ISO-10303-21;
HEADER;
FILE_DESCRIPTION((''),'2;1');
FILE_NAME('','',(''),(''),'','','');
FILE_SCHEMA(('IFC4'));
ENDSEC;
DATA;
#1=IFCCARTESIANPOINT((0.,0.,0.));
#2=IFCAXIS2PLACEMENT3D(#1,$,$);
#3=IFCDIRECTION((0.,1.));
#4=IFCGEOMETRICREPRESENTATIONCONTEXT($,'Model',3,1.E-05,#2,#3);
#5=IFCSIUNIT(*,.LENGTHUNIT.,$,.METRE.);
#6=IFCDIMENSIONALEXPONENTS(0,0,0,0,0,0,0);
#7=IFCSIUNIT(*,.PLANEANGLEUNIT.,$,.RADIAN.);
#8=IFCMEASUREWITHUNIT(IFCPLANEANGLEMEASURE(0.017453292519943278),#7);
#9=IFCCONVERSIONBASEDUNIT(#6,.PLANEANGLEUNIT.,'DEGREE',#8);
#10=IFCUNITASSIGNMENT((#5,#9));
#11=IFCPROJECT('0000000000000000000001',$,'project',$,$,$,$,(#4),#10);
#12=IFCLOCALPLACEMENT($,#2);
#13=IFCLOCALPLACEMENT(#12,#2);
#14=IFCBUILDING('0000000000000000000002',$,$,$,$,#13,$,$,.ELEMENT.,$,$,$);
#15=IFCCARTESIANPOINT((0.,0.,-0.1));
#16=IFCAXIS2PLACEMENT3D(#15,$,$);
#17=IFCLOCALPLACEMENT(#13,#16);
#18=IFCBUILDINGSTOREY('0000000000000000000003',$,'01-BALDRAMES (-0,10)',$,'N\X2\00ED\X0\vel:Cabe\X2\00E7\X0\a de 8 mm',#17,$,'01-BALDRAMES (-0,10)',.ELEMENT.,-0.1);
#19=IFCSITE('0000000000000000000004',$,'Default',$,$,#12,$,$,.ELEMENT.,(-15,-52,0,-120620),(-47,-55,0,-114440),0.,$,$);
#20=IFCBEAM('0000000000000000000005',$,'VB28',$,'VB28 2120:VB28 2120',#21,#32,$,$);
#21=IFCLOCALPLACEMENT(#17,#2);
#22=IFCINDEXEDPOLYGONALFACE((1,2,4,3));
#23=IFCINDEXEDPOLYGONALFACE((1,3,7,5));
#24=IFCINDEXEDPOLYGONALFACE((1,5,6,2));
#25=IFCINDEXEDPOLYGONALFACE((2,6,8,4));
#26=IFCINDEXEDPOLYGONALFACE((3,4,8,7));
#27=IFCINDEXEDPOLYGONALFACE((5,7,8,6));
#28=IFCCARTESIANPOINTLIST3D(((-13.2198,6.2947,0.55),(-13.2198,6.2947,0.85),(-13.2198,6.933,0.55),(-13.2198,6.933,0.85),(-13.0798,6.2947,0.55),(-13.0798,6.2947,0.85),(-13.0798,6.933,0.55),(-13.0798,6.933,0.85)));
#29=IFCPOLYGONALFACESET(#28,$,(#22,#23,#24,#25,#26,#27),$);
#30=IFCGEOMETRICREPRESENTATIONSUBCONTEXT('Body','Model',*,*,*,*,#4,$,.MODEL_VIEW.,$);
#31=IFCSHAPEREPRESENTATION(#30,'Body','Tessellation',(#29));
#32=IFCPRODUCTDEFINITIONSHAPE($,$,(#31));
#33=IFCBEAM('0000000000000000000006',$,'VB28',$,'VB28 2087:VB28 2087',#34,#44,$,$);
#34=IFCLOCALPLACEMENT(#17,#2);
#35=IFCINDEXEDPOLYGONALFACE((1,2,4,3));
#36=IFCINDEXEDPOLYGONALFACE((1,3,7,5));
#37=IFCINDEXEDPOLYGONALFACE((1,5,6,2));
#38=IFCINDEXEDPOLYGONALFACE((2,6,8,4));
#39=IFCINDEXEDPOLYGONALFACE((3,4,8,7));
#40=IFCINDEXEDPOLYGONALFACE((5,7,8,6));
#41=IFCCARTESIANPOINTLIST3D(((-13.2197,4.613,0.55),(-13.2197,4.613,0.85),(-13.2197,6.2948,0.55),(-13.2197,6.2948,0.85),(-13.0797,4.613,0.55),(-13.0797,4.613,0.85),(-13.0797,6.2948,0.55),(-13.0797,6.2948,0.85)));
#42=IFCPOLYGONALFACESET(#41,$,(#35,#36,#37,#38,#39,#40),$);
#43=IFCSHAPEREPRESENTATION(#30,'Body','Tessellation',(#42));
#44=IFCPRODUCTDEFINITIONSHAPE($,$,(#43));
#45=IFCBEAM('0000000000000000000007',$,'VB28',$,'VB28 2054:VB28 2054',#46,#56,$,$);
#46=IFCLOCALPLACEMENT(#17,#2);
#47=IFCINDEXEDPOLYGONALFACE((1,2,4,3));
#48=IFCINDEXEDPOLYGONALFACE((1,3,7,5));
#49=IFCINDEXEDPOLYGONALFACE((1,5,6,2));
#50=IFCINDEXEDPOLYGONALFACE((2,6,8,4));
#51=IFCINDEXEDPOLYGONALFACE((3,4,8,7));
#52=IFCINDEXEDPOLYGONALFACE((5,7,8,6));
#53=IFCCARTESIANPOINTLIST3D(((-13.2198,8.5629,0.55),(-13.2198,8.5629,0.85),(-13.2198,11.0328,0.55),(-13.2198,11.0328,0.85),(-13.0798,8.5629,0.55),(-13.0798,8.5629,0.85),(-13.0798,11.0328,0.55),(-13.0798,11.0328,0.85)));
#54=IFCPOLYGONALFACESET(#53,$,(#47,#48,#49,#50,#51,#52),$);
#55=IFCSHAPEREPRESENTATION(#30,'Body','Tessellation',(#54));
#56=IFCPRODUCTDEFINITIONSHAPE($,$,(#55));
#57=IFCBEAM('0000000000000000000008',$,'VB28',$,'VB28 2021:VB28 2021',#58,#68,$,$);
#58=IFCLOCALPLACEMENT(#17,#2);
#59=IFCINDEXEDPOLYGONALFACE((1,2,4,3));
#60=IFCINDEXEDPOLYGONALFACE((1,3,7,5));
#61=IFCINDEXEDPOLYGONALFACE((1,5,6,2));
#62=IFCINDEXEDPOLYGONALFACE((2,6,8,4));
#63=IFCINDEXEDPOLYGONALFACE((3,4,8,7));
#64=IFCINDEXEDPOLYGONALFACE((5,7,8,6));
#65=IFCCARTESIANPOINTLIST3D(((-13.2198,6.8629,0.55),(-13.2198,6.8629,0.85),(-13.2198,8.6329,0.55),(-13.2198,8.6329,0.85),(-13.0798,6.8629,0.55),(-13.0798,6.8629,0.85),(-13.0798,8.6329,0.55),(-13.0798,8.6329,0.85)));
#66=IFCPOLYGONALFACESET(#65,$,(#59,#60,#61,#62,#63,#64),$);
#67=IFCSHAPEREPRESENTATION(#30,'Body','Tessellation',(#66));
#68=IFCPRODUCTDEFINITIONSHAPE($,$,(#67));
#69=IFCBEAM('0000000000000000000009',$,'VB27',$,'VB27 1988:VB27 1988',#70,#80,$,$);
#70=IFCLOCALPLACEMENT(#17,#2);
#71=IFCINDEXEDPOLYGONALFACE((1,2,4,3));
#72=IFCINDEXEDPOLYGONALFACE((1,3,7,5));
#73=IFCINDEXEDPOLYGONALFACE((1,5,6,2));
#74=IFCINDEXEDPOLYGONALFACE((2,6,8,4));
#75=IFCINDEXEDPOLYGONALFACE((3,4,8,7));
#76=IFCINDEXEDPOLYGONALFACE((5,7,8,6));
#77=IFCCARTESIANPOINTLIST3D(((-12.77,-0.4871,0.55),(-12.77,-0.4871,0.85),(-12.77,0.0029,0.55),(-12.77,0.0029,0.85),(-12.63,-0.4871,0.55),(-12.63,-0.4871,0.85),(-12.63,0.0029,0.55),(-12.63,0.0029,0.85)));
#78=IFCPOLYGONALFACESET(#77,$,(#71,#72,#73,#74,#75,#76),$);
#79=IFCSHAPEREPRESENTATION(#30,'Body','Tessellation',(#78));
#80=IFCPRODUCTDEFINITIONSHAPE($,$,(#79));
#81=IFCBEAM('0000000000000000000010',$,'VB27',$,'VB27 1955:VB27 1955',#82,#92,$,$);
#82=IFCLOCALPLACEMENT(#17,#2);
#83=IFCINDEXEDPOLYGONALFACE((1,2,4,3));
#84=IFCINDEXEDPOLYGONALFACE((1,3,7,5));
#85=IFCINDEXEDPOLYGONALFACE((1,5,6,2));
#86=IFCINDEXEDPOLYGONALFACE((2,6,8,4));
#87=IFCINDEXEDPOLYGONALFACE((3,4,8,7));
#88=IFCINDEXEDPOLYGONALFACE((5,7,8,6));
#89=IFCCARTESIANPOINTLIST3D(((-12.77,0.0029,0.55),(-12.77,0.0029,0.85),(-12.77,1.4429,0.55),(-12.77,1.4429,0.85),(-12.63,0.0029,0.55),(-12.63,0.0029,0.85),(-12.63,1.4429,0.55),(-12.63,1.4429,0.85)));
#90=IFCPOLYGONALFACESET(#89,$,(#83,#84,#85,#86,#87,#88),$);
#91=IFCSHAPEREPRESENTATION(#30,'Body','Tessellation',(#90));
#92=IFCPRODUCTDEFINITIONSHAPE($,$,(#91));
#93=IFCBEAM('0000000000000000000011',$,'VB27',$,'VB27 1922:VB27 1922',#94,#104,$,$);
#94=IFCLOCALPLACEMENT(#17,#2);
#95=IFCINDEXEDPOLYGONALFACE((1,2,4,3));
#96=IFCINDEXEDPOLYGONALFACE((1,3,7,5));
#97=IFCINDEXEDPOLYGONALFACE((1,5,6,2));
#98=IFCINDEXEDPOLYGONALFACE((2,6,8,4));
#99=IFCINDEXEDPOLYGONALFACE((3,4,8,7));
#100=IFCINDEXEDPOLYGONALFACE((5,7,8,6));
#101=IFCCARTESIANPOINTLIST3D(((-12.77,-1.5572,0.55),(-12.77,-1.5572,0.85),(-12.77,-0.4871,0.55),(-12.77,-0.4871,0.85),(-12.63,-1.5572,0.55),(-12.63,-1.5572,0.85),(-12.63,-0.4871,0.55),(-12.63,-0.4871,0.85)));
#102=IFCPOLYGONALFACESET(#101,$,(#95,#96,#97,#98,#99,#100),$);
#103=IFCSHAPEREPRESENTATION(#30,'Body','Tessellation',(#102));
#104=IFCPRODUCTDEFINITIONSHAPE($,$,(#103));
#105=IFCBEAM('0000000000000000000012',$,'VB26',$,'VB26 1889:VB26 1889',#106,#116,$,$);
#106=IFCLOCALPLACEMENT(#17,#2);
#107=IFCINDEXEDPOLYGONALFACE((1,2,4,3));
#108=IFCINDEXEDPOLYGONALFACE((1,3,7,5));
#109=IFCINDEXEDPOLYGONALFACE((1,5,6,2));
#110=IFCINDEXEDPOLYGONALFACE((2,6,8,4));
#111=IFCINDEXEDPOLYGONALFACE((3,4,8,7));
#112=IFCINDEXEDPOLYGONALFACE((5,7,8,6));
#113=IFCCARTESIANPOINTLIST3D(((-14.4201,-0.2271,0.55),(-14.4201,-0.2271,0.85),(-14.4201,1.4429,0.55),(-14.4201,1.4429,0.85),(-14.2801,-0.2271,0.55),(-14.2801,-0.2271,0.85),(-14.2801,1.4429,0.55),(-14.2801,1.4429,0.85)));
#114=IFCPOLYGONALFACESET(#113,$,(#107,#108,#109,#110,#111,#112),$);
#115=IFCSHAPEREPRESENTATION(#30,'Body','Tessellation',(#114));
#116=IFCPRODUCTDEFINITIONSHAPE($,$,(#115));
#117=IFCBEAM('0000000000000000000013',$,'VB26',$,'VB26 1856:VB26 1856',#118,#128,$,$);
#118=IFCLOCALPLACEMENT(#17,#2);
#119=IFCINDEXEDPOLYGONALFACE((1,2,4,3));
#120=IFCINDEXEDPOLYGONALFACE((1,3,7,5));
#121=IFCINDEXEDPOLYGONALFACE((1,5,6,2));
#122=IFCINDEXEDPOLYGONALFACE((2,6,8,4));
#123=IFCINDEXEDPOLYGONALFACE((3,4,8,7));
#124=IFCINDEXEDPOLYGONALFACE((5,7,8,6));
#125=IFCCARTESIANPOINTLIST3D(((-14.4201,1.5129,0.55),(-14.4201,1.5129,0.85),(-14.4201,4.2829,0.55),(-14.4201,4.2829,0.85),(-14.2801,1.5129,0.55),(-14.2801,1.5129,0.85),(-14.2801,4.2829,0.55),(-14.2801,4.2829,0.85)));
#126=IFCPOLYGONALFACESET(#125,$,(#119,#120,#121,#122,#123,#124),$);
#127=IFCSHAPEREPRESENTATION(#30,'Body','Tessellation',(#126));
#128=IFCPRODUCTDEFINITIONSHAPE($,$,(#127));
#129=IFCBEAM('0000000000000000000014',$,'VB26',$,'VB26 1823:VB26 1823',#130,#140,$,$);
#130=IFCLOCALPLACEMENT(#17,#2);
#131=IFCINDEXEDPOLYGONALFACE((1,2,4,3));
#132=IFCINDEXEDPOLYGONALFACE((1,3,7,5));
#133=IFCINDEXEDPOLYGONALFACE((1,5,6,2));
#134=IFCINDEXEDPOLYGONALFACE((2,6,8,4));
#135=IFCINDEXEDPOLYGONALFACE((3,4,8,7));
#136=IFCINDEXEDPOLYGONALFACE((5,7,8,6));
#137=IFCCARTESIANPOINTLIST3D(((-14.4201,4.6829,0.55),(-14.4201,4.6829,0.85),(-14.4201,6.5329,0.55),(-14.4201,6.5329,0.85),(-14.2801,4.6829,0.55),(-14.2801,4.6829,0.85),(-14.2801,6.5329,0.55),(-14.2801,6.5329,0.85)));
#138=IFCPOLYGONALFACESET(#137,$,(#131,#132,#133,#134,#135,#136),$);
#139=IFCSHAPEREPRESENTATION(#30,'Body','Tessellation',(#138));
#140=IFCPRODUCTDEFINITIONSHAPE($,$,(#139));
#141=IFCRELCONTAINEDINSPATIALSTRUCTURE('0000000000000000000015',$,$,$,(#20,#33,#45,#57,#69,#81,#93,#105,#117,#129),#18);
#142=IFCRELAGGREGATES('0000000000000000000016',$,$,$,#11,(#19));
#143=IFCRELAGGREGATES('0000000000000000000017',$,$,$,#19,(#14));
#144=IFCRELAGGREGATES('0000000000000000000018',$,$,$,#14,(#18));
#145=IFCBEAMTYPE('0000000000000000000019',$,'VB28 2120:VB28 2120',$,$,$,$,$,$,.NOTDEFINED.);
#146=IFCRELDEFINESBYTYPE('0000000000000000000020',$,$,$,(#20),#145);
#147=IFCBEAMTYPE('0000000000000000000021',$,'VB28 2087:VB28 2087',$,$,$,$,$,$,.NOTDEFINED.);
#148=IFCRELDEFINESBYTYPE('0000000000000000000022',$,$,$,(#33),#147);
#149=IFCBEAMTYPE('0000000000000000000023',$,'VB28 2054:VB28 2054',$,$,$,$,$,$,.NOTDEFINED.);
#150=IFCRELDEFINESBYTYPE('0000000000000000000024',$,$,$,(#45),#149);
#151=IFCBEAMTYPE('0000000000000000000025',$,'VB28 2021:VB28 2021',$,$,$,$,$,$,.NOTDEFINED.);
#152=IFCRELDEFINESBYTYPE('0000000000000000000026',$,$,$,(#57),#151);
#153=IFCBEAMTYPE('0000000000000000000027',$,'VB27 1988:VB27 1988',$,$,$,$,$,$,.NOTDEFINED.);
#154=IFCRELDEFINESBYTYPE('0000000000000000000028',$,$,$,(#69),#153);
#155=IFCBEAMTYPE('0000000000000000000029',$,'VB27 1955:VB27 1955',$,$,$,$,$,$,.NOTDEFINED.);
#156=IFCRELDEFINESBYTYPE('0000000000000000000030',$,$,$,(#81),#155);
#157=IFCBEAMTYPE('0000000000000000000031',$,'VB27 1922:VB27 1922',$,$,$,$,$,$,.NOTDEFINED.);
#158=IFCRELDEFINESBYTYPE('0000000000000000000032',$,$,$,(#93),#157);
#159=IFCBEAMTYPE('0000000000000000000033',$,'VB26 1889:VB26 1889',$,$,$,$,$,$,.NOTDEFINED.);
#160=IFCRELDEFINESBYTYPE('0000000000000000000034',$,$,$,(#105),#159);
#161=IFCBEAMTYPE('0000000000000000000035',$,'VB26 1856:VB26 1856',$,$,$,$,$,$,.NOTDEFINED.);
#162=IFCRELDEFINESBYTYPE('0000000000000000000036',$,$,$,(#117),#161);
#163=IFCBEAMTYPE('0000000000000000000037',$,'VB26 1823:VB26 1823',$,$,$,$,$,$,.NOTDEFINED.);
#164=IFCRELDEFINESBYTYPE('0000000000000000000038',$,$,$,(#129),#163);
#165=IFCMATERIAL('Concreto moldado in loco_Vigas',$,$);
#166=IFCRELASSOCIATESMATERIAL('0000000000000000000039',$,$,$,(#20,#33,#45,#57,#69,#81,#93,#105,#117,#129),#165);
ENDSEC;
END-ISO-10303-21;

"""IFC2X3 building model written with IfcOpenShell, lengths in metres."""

from ifc_helpers import new_model, entity, si_unit, converted_unit, direction, frame, frame_2d, origin, place, context, subcontext, project, spatial, rectangle, extrude, material, type_object, element, save


model = new_model("IFC2X3")

# Units and contexts
model_context = context("Model", 3, precision=1e-05, world=origin(), true_north=direction((0.0, 1.0)))
body_context = subcontext(model_context, "Body", "Model", "MODEL_VIEW")
ifc_project = project(units=[si_unit("LENGTHUNIT", "METRE"), converted_unit("PLANEANGLEUNIT", "DEGREE", entity("IfcPlaneAngleMeasure", 0.017453292519943278), si_unit("PLANEANGLEUNIT", "RADIAN"), dimensions=[0, 0, 0, 0, 0, 0, 0])], contexts=[model_context])

# Site, building, storey
site_placement = place(None, origin())
site = spatial("IfcSite", under=ifc_project, at=site_placement, Name="Default", CompositionType="ELEMENT", RefLatitude=(-15, -52, 0, -120620), RefLongitude=(-47, -55, 0, -114440), RefElevation=0.0)
building_placement = place(site_placement, origin())
building = spatial("IfcBuilding", under=site, at=building_placement, CompositionType="ELEMENT")
storey_placement = place(building_placement, frame((0.0, 0.0, -0.1)))
storey = spatial("IfcBuildingStorey", under=building, at=storey_placement, Name="01-BALDRAMES (-0,10)", ObjectType="Nível:Cabeça de 8 mm", LongName="01-BALDRAMES (-0,10)", CompositionType="ELEMENT", Elevation=-0.1)

# Beams
ifc_material = material(Name="Concreto moldado in loco_Vigas")
beam_type_1 = type_object("IfcBeamType", Name="VB28 2120:VB28 2120", PredefinedType="NOTDEFINED")
beam_1_placement = place(storey_placement, origin())
element("IfcBeam", 1, at=beam_1_placement, inside=storey, type_object=beam_type_1, material=ifc_material, Name="VB28", ObjectType="VB28 2120:VB28 2120", context=body_context, shape_type="SweptSolid", body=[
    extrude(rectangle(XDim=0.3, YDim=0.6382, at=frame_2d((0.0, 0.0), x_axis=(0.0, 1.0))), frame((-13.2198, 6.6139, 0.7), z_axis=(1.0, 0.0, 0.0), x_axis=(0.0, -1.0, 0.0)), (0.0, 0.0, 1.0), 0.14),
])
beam_type_2 = type_object("IfcBeamType", Name="VB28 2087:VB28 2087", PredefinedType="NOTDEFINED")
beam_2_placement = place(storey_placement, origin())
element("IfcBeam", 2, at=beam_2_placement, inside=storey, type_object=beam_type_2, material=ifc_material, Name="VB28", ObjectType="VB28 2087:VB28 2087", context=body_context, shape_type="SweptSolid", body=[
    extrude(rectangle(XDim=0.3, YDim=1.6817, at=frame_2d((0.0, 0.0), x_axis=(0.0, 1.0))), frame((-13.2197, 5.4539, 0.7), z_axis=(1.0, 0.0, 0.0), x_axis=(0.0, -1.0, 0.0)), (0.0, 0.0, 1.0), 0.14),
])
beam_type_3 = type_object("IfcBeamType", Name="VB28 2054:VB28 2054", PredefinedType="NOTDEFINED")
beam_3_placement = place(storey_placement, origin())
element("IfcBeam", 3, at=beam_3_placement, inside=storey, type_object=beam_type_3, material=ifc_material, Name="VB28", ObjectType="VB28 2054:VB28 2054", context=body_context, shape_type="SweptSolid", body=[
    extrude(rectangle(XDim=0.3, YDim=2.4699, at=frame_2d((0.0, 0.0), x_axis=(0.0, 1.0))), frame((-13.2198, 9.7979, 0.7), z_axis=(1.0, 0.0, 0.0), x_axis=(0.0, -1.0, 0.0)), (0.0, 0.0, 1.0), 0.14),
])
beam_type_4 = type_object("IfcBeamType", Name="VB28 2021:VB28 2021", PredefinedType="NOTDEFINED")
beam_4_placement = place(storey_placement, origin())
element("IfcBeam", 4, at=beam_4_placement, inside=storey, type_object=beam_type_4, material=ifc_material, Name="VB28", ObjectType="VB28 2021:VB28 2021", context=body_context, shape_type="SweptSolid", body=[
    extrude(rectangle(XDim=0.3, YDim=1.77, at=frame_2d((0.0, 0.0), x_axis=(0.0, 1.0))), frame((-13.2198, 7.7479, 0.7), z_axis=(1.0, 0.0, 0.0), x_axis=(0.0, -1.0, 0.0)), (0.0, 0.0, 1.0), 0.14),
])
beam_type_5 = type_object("IfcBeamType", Name="VB27 1988:VB27 1988", PredefinedType="NOTDEFINED")
beam_5_placement = place(storey_placement, origin())
element("IfcBeam", 5, at=beam_5_placement, inside=storey, type_object=beam_type_5, material=ifc_material, Name="VB27", ObjectType="VB27 1988:VB27 1988", context=body_context, shape_type="SweptSolid", body=[
    extrude(rectangle(XDim=0.3, YDim=0.49, at=frame_2d((0.0, 0.0), x_axis=(0.0, 1.0))), frame((-12.77, -0.2421, 0.7), z_axis=(1.0, 0.0, 0.0), x_axis=(0.0, -1.0, 0.0)), (0.0, 0.0, 1.0), 0.14),
])
beam_type_6 = type_object("IfcBeamType", Name="VB27 1955:VB27 1955", PredefinedType="NOTDEFINED")
beam_6_placement = place(storey_placement, origin())
element("IfcBeam", 6, at=beam_6_placement, inside=storey, type_object=beam_type_6, material=ifc_material, Name="VB27", ObjectType="VB27 1955:VB27 1955", context=body_context, shape_type="SweptSolid", body=[
    extrude(rectangle(XDim=0.3, YDim=1.44, at=frame_2d((0.0, 0.0), x_axis=(0.0, 1.0))), frame((-12.77, 0.7229, 0.7), z_axis=(1.0, 0.0, 0.0), x_axis=(0.0, -1.0, 0.0)), (0.0, 0.0, 1.0), 0.14),
])
beam_type_7 = type_object("IfcBeamType", Name="VB27 1922:VB27 1922", PredefinedType="NOTDEFINED")
beam_7_placement = place(storey_placement, origin())
element("IfcBeam", 7, at=beam_7_placement, inside=storey, type_object=beam_type_7, material=ifc_material, Name="VB27", ObjectType="VB27 1922:VB27 1922", context=body_context, shape_type="SweptSolid", body=[
    extrude(rectangle(XDim=0.3, YDim=1.0701, at=frame_2d((0.0, 0.0), x_axis=(0.0, 1.0))), frame((-12.77, -1.0221, 0.7), z_axis=(1.0, 0.0, 0.0), x_axis=(0.0, -1.0, 0.0)), (0.0, 0.0, 1.0), 0.14),
])
beam_type_8 = type_object("IfcBeamType", Name="VB26 1889:VB26 1889", PredefinedType="NOTDEFINED")
beam_8_placement = place(storey_placement, origin())
element("IfcBeam", 8, at=beam_8_placement, inside=storey, type_object=beam_type_8, material=ifc_material, Name="VB26", ObjectType="VB26 1889:VB26 1889", context=body_context, shape_type="SweptSolid", body=[
    extrude(rectangle(XDim=0.3, YDim=1.67, at=frame_2d((0.0, 0.0), x_axis=(0.0, 1.0))), frame((-14.4201, 0.6079, 0.7), z_axis=(1.0, 0.0, 0.0), x_axis=(0.0, -1.0, 0.0)), (0.0, 0.0, 1.0), 0.14),
])
beam_type_9 = type_object("IfcBeamType", Name="VB26 1856:VB26 1856", PredefinedType="NOTDEFINED")
beam_9_placement = place(storey_placement, origin())
element("IfcBeam", 9, at=beam_9_placement, inside=storey, type_object=beam_type_9, material=ifc_material, Name="VB26", ObjectType="VB26 1856:VB26 1856", context=body_context, shape_type="SweptSolid", body=[
    extrude(rectangle(XDim=0.3, YDim=2.77, at=frame_2d((0.0, 0.0), x_axis=(0.0, 1.0))), frame((-14.4201, 2.8979, 0.7), z_axis=(1.0, 0.0, 0.0), x_axis=(0.0, -1.0, 0.0)), (0.0, 0.0, 1.0), 0.14),
])
beam_type_10 = type_object("IfcBeamType", Name="VB26 1823:VB26 1823", PredefinedType="NOTDEFINED")
beam_10_placement = place(storey_placement, origin())
element("IfcBeam", 10, at=beam_10_placement, inside=storey, type_object=beam_type_10, material=ifc_material, Name="VB26", ObjectType="VB26 1823:VB26 1823", context=body_context, shape_type="SweptSolid", body=[
    extrude(rectangle(XDim=0.3, YDim=1.85, at=frame_2d((0.0, 0.0), x_axis=(0.0, 1.0))), frame((-14.4201, 5.6079, 0.7), z_axis=(1.0, 0.0, 0.0), x_axis=(0.0, -1.0, 0.0)), (0.0, 0.0, 1.0), 0.14),
])

save(model, "model.ifc")
